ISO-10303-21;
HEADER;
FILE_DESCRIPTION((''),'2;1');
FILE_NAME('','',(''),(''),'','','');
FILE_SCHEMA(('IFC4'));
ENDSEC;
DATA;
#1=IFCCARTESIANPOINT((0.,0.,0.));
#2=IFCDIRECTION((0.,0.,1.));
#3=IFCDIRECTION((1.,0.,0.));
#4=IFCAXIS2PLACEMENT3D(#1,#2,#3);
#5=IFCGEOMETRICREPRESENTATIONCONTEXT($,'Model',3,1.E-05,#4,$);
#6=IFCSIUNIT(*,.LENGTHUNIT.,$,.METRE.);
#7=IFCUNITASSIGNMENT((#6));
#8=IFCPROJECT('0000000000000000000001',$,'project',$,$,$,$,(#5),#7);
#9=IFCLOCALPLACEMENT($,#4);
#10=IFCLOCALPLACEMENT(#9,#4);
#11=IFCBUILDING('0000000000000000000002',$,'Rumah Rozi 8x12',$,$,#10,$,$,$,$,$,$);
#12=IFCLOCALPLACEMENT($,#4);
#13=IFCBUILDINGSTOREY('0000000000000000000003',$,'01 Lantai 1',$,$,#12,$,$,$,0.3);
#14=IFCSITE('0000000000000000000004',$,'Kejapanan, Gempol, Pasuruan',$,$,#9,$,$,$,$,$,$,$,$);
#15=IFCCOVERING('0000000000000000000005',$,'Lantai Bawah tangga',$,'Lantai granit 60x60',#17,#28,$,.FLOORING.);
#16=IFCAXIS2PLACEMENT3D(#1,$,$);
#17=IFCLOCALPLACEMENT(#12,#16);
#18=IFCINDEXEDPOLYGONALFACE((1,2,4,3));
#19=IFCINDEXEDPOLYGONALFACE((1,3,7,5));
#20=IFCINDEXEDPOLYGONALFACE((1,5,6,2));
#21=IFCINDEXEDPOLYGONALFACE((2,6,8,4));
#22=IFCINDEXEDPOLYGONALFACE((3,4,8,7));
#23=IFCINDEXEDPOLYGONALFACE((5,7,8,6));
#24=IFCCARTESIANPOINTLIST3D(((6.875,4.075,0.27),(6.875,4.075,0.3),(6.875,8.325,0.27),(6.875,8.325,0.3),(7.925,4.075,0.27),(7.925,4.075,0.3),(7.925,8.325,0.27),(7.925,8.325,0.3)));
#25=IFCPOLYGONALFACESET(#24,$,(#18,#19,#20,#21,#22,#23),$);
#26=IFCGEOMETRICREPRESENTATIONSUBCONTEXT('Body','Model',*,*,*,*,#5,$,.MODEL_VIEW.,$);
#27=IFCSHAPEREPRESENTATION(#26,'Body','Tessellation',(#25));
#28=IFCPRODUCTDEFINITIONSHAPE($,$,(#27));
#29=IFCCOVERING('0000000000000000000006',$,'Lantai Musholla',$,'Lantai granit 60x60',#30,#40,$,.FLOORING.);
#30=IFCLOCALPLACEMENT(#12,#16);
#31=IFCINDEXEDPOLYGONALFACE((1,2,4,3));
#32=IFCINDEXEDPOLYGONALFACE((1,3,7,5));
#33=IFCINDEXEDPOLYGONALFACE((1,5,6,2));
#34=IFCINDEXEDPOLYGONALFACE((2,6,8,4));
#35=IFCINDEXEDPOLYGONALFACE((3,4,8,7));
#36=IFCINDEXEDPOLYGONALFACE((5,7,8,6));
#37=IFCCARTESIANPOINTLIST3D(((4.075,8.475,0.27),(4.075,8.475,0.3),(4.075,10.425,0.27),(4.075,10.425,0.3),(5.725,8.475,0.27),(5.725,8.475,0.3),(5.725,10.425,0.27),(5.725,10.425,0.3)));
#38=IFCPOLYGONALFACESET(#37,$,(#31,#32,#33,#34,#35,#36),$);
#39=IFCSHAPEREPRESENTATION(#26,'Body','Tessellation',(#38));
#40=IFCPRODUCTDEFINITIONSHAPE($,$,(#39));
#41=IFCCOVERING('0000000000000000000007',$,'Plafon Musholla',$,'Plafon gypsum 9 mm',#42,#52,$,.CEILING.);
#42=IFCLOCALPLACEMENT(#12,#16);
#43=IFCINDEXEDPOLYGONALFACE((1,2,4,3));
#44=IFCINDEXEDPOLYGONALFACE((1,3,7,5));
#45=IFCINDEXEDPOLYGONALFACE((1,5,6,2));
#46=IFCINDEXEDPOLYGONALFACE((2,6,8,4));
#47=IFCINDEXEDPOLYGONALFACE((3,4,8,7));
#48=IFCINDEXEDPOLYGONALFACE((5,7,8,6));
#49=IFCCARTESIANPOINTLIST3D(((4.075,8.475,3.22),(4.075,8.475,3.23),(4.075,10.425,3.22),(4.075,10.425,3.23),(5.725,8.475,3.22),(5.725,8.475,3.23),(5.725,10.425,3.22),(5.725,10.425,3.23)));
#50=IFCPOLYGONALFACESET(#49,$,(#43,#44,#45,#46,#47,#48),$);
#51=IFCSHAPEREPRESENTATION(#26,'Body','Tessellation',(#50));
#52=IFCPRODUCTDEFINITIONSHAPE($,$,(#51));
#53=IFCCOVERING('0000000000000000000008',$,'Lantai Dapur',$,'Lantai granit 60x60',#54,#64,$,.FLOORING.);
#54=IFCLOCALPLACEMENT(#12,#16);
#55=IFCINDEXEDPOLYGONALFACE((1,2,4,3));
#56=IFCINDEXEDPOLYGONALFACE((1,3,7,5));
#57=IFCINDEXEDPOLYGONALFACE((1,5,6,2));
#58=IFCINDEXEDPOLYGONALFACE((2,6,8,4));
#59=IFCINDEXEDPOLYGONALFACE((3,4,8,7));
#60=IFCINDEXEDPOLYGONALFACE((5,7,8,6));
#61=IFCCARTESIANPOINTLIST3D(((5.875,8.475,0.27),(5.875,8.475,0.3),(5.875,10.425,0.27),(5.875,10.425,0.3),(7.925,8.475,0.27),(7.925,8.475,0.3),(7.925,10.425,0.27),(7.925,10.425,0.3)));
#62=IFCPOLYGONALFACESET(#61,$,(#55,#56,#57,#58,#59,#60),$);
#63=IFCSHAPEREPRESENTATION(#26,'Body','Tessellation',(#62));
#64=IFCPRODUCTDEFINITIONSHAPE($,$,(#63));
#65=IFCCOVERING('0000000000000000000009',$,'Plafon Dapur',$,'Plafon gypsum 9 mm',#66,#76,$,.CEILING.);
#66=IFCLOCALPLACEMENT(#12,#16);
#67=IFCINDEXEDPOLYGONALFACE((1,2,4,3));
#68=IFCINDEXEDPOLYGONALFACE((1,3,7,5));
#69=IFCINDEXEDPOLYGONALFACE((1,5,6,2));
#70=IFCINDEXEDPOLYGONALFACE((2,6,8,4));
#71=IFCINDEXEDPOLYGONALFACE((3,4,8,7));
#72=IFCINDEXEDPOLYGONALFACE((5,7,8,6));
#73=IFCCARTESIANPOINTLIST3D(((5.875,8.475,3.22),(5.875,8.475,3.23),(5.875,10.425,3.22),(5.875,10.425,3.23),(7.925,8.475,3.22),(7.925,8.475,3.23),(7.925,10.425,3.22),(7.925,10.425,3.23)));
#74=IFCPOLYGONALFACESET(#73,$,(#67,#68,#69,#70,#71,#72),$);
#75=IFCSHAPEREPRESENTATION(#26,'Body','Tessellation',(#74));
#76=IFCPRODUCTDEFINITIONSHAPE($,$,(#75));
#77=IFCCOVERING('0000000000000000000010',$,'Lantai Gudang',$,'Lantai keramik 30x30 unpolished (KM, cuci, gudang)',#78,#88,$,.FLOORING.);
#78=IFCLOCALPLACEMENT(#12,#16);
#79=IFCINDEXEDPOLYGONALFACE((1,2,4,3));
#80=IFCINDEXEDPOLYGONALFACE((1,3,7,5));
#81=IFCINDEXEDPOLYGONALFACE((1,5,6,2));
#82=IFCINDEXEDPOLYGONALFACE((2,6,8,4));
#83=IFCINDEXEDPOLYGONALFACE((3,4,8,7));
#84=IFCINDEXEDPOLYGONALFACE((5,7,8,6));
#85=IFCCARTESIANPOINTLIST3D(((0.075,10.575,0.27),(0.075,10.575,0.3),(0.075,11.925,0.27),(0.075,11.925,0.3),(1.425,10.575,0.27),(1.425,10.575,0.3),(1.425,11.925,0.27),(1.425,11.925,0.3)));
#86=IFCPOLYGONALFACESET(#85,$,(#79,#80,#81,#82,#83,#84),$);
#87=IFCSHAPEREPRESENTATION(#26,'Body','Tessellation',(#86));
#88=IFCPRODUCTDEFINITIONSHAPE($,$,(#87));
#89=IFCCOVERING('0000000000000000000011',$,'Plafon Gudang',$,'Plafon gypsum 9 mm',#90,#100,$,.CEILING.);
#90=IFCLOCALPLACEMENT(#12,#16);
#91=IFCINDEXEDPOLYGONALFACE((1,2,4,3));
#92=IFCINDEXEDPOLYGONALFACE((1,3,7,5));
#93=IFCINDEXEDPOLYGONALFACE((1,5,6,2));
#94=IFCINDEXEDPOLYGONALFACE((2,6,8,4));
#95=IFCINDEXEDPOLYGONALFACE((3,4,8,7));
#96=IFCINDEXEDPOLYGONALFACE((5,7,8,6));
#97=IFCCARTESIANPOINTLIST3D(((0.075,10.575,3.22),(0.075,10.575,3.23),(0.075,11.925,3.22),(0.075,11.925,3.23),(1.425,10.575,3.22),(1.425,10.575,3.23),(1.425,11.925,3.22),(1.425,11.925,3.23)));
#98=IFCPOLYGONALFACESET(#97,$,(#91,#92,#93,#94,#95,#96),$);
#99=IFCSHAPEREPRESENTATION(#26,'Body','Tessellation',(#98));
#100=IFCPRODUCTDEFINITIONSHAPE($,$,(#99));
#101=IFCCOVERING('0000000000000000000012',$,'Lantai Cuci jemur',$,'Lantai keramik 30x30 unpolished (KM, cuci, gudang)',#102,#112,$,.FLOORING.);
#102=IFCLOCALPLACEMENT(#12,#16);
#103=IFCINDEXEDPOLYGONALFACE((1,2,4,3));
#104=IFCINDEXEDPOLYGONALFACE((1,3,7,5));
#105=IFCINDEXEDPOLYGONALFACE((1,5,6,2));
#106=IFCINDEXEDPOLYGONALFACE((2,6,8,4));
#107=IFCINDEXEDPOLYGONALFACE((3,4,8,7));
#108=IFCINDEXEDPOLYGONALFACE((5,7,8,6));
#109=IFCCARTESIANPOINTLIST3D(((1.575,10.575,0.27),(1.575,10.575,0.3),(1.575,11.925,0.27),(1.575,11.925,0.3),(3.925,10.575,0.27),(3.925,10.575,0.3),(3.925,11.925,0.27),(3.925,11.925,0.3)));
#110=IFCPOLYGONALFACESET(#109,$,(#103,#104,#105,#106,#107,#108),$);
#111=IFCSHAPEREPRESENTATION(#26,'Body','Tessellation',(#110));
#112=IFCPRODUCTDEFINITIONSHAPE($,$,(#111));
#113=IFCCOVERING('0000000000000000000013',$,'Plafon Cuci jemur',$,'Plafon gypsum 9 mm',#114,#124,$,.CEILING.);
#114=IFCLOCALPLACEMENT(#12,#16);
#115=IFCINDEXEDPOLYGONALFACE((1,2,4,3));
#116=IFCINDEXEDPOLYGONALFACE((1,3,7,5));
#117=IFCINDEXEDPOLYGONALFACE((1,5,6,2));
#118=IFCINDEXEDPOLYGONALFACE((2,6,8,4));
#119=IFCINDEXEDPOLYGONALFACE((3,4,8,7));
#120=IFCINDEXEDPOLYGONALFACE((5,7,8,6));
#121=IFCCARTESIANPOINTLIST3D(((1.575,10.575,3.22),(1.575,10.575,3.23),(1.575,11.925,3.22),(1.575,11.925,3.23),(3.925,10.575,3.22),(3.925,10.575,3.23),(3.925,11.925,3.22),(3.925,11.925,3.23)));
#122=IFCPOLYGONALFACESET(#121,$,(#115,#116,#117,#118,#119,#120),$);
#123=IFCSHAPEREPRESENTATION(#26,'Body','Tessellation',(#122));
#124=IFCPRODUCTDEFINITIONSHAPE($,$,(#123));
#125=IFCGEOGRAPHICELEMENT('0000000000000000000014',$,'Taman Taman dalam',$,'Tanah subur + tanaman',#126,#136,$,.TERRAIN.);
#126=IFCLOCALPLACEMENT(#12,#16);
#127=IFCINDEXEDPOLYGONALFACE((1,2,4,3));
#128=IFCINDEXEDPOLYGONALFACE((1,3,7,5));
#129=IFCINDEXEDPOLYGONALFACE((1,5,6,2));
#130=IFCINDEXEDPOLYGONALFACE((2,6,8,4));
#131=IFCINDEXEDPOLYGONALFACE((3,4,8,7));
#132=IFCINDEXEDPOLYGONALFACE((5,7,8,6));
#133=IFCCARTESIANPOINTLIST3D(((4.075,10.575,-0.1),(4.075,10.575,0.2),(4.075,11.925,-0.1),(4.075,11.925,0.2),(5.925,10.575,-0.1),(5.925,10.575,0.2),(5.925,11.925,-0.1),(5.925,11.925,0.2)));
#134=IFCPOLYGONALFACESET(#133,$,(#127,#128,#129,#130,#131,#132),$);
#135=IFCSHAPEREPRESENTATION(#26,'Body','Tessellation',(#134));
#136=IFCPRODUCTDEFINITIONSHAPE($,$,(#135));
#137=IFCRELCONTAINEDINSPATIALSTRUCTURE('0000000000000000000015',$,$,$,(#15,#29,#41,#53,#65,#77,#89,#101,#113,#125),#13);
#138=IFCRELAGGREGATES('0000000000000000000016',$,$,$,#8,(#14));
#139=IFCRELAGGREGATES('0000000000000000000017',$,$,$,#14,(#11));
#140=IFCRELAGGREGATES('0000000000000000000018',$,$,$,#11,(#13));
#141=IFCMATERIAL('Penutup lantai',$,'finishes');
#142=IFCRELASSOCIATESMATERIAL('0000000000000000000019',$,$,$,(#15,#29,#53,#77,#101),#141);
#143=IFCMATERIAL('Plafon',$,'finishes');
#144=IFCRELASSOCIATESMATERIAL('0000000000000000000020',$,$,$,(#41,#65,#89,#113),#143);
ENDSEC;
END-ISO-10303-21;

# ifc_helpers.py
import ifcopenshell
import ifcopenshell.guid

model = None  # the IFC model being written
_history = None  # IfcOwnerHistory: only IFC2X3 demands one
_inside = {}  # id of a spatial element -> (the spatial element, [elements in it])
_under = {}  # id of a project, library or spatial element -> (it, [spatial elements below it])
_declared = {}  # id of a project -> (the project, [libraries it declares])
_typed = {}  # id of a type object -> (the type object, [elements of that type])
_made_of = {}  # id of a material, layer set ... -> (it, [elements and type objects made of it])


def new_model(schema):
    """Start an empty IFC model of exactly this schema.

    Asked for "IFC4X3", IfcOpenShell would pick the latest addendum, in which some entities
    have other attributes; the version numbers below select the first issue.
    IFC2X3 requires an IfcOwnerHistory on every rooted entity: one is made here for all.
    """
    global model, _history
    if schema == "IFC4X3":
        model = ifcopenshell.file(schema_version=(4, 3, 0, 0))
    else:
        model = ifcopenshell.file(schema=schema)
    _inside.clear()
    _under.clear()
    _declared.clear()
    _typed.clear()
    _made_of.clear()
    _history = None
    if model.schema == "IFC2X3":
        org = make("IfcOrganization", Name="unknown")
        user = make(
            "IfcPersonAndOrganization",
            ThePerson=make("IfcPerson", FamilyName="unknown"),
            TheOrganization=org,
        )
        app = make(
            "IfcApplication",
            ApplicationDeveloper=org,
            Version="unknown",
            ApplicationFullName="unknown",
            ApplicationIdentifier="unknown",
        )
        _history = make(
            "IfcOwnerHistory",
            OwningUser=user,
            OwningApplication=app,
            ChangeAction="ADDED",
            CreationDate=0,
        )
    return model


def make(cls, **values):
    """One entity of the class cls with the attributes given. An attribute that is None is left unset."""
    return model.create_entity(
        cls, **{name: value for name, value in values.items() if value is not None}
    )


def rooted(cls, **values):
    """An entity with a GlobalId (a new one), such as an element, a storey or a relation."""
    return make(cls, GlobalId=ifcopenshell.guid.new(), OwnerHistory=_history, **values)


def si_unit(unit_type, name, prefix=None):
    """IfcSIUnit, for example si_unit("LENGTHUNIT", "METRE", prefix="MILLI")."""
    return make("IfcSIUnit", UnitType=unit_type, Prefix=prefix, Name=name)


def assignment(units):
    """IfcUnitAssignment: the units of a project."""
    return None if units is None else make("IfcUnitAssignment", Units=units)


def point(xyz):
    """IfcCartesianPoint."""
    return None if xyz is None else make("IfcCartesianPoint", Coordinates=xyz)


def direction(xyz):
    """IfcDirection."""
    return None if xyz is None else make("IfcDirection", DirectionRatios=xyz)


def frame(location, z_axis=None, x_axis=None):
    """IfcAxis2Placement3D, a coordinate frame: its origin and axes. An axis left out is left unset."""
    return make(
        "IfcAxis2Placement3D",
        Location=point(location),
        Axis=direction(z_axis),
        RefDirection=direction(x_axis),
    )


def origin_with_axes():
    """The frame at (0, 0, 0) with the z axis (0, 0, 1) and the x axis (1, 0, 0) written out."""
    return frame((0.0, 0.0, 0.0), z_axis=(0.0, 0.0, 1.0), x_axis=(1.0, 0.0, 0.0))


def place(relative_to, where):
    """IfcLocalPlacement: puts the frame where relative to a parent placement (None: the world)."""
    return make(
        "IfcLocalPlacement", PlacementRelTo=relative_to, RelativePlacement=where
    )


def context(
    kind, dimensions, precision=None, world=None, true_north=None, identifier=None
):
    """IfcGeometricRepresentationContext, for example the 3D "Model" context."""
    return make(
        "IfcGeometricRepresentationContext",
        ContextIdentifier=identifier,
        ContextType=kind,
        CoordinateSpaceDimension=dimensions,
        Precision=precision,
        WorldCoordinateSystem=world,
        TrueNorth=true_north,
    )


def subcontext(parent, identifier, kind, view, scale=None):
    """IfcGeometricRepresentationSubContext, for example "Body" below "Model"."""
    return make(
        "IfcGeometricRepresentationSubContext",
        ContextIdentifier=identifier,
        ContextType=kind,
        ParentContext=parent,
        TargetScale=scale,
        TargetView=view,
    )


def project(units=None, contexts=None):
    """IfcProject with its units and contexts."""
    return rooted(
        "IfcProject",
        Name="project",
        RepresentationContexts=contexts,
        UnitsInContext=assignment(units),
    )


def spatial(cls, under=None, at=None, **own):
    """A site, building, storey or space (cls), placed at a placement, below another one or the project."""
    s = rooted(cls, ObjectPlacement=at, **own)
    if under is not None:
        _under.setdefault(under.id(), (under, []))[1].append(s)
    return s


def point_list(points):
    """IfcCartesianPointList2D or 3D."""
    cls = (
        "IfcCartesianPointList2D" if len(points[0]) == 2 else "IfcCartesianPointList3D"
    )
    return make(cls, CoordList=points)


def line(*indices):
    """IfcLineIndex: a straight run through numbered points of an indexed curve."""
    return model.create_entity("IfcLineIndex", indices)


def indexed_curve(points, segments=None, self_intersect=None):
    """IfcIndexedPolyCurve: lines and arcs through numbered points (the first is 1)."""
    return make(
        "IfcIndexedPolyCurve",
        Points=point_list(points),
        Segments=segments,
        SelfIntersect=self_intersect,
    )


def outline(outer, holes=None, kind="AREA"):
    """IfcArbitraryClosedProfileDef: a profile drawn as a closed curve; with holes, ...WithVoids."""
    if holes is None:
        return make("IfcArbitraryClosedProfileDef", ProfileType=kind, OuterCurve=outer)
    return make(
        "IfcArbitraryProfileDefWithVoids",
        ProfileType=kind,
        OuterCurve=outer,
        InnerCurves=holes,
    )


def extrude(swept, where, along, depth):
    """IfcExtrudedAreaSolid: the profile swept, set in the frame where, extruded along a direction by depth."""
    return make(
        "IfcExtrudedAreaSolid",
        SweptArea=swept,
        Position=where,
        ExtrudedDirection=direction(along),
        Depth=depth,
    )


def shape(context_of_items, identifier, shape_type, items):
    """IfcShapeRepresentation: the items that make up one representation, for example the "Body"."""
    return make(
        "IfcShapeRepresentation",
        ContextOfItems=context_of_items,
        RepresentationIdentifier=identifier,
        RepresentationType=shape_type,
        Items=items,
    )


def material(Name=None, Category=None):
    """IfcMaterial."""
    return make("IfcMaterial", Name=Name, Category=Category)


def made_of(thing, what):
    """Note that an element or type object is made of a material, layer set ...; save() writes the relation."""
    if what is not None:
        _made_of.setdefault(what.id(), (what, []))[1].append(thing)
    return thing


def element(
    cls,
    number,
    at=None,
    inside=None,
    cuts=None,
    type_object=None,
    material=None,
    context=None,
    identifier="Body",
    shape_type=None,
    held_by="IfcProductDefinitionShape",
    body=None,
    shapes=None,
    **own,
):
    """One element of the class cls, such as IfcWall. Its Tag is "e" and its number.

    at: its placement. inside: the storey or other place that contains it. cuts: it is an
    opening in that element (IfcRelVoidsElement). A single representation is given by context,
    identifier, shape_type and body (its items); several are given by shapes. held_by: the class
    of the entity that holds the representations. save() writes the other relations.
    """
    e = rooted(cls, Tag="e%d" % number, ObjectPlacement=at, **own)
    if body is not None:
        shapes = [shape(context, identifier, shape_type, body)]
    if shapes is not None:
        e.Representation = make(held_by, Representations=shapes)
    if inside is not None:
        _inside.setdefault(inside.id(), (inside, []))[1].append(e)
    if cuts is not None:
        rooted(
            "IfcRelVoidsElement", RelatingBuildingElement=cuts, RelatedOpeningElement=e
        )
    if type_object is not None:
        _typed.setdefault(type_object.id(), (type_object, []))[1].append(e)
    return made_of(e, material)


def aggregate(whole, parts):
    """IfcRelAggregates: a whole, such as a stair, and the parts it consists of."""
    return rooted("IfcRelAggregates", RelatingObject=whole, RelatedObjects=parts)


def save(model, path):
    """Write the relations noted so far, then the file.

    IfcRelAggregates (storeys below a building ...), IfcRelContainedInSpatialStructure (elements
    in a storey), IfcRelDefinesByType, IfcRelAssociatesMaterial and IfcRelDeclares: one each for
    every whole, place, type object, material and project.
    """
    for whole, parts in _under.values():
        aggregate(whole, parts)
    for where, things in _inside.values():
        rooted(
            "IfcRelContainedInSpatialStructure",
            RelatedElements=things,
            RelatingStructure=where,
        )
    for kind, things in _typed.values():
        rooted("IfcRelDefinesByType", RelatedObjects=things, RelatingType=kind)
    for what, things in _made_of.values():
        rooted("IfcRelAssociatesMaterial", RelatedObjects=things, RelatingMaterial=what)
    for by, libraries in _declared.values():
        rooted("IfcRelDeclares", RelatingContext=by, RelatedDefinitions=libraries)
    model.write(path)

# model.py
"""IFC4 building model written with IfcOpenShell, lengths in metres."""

from ifc_helpers import new_model, si_unit, frame, origin_with_axes, place, context, subcontext, project, spatial, line, indexed_curve, outline, extrude, material, element, save


model = new_model("IFC4")

# Units and contexts
model_context = context("Model", 3, precision=1e-05, world=origin_with_axes())
body_context = subcontext(model_context, "Body", "Model", "MODEL_VIEW")
ifc_project = project(units=[si_unit("LENGTHUNIT", "METRE")], contexts=[model_context])

# Site, building, storey
site_placement = place(None, origin_with_axes())
site = spatial("IfcSite", under=ifc_project, at=site_placement, Name="Kejapanan, Gempol, Pasuruan")
building_placement = place(site_placement, origin_with_axes())
building = spatial("IfcBuilding", under=site, at=building_placement, Name="Rumah Rozi 8x12")
storey_placement = place(None, origin_with_axes())
storey = spatial("IfcBuildingStorey", under=building, at=storey_placement, Name="01 Lantai 1", Elevation=0.3)

# Coverings
ifc_material_1 = material(Name="Penutup lantai", Category="finishes")
ifc_material_2 = material(Name="Plafon", Category="finishes")
covering_1_placement = place(storey_placement, origin_with_axes())
element("IfcCovering", 1, at=covering_1_placement, inside=storey, material=ifc_material_1, Name="Lantai Bawah tangga", ObjectType="Lantai granit 60x60", PredefinedType="FLOORING", context=body_context, shape_type="SweptSolid", body=[
    extrude(outline(indexed_curve([(6.875, 4.075), (7.925, 4.075), (7.925, 8.325), (6.875, 8.325)], segments=[line(1, 2, 3, 4, 1)])), frame((0.0, 0.0, 0.27), z_axis=(0.0, 0.0, 1.0), x_axis=(1.0, 0.0, 0.0)), (0.0, 0.0, 1.0), 0.03),
])
covering_2_placement = place(storey_placement, origin_with_axes())
element("IfcCovering", 2, at=covering_2_placement, inside=storey, material=ifc_material_1, Name="Lantai Musholla", ObjectType="Lantai granit 60x60", PredefinedType="FLOORING", context=body_context, shape_type="SweptSolid", body=[
    extrude(outline(indexed_curve([(4.075, 8.475), (5.725, 8.475), (5.725, 10.425), (4.075, 10.425)], segments=[line(1, 2, 3, 4, 1)])), frame((0.0, 0.0, 0.27), z_axis=(0.0, 0.0, 1.0), x_axis=(1.0, 0.0, 0.0)), (0.0, 0.0, 1.0), 0.03),
])
covering_3_placement = place(storey_placement, origin_with_axes())
element("IfcCovering", 3, at=covering_3_placement, inside=storey, material=ifc_material_2, Name="Plafon Musholla", ObjectType="Plafon gypsum 9 mm", PredefinedType="CEILING", context=body_context, shape_type="SweptSolid", body=[
    extrude(outline(indexed_curve([(4.075, 8.475), (5.725, 8.475), (5.725, 10.425), (4.075, 10.425)], segments=[line(1, 2, 3, 4, 1)])), frame((0.0, 0.0, 3.22), z_axis=(0.0, 0.0, 1.0), x_axis=(1.0, 0.0, 0.0)), (0.0, 0.0, 1.0), 0.01),
])
covering_4_placement = place(storey_placement, origin_with_axes())
element("IfcCovering", 4, at=covering_4_placement, inside=storey, material=ifc_material_1, Name="Lantai Dapur", ObjectType="Lantai granit 60x60", PredefinedType="FLOORING", context=body_context, shape_type="SweptSolid", body=[
    extrude(outline(indexed_curve([(5.875, 8.475), (7.925, 8.475), (7.925, 10.425), (5.875, 10.425)], segments=[line(1, 2, 3, 4, 1)])), frame((0.0, 0.0, 0.27), z_axis=(0.0, 0.0, 1.0), x_axis=(1.0, 0.0, 0.0)), (0.0, 0.0, 1.0), 0.03),
])
covering_5_placement = place(storey_placement, origin_with_axes())
element("IfcCovering", 5, at=covering_5_placement, inside=storey, material=ifc_material_2, Name="Plafon Dapur", ObjectType="Plafon gypsum 9 mm", PredefinedType="CEILING", context=body_context, shape_type="SweptSolid", body=[
    extrude(outline(indexed_curve([(5.875, 8.475), (7.925, 8.475), (7.925, 10.425), (5.875, 10.425)], segments=[line(1, 2, 3, 4, 1)])), frame((0.0, 0.0, 3.22), z_axis=(0.0, 0.0, 1.0), x_axis=(1.0, 0.0, 0.0)), (0.0, 0.0, 1.0), 0.01),
])
covering_6_placement = place(storey_placement, origin_with_axes())
element("IfcCovering", 6, at=covering_6_placement, inside=storey, material=ifc_material_1, Name="Lantai Gudang", ObjectType="Lantai keramik 30x30 unpolished (KM, cuci, gudang)", PredefinedType="FLOORING", context=body_context, shape_type="SweptSolid", body=[
    extrude(outline(indexed_curve([(0.075, 10.575), (1.425, 10.575), (1.425, 11.925), (0.075, 11.925)], segments=[line(1, 2, 3, 4, 1)])), frame((0.0, 0.0, 0.27), z_axis=(0.0, 0.0, 1.0), x_axis=(1.0, 0.0, 0.0)), (0.0, 0.0, 1.0), 0.03),
])
covering_7_placement = place(storey_placement, origin_with_axes())
element("IfcCovering", 7, at=covering_7_placement, inside=storey, material=ifc_material_2, Name="Plafon Gudang", ObjectType="Plafon gypsum 9 mm", PredefinedType="CEILING", context=body_context, shape_type="SweptSolid", body=[
    extrude(outline(indexed_curve([(0.075, 10.575), (1.425, 10.575), (1.425, 11.925), (0.075, 11.925)], segments=[line(1, 2, 3, 4, 1)])), frame((0.0, 0.0, 3.22), z_axis=(0.0, 0.0, 1.0), x_axis=(1.0, 0.0, 0.0)), (0.0, 0.0, 1.0), 0.01),
])
covering_8_placement = place(storey_placement, origin_with_axes())
element("IfcCovering", 8, at=covering_8_placement, inside=storey, material=ifc_material_1, Name="Lantai Cuci jemur", ObjectType="Lantai keramik 30x30 unpolished (KM, cuci, gudang)", PredefinedType="FLOORING", context=body_context, shape_type="SweptSolid", body=[
    extrude(outline(indexed_curve([(1.575, 10.575), (3.925, 10.575), (3.925, 11.925), (1.575, 11.925)], segments=[line(1, 2, 3, 4, 1)])), frame((0.0, 0.0, 0.27), z_axis=(0.0, 0.0, 1.0), x_axis=(1.0, 0.0, 0.0)), (0.0, 0.0, 1.0), 0.03),
])
covering_9_placement = place(storey_placement, origin_with_axes())
element("IfcCovering", 9, at=covering_9_placement, inside=storey, material=ifc_material_2, Name="Plafon Cuci jemur", ObjectType="Plafon gypsum 9 mm", PredefinedType="CEILING", context=body_context, shape_type="SweptSolid", body=[
    extrude(outline(indexed_curve([(1.575, 10.575), (3.925, 10.575), (3.925, 11.925), (1.575, 11.925)], segments=[line(1, 2, 3, 4, 1)])), frame((0.0, 0.0, 3.22), z_axis=(0.0, 0.0, 1.0), x_axis=(1.0, 0.0, 0.0)), (0.0, 0.0, 1.0), 0.01),
])

# Geographic element
geographic_element_placement = place(storey_placement, origin_with_axes())
element("IfcGeographicElement", 10, at=geographic_element_placement, inside=storey, Name="Taman Taman dalam", ObjectType="Tanah subur + tanaman", PredefinedType="TERRAIN", context=body_context, shape_type="SweptSolid", body=[
    extrude(outline(indexed_curve([(4.075, 10.575), (5.925, 10.575), (5.925, 11.925), (4.075, 11.925)], segments=[line(1, 2, 3, 4, 1)])), frame((0.0, 0.0, -0.1), z_axis=(0.0, 0.0, 1.0), x_axis=(1.0, 0.0, 0.0)), (0.0, 0.0, 1.0), 0.3),
])

save(model, "model.ifc")
